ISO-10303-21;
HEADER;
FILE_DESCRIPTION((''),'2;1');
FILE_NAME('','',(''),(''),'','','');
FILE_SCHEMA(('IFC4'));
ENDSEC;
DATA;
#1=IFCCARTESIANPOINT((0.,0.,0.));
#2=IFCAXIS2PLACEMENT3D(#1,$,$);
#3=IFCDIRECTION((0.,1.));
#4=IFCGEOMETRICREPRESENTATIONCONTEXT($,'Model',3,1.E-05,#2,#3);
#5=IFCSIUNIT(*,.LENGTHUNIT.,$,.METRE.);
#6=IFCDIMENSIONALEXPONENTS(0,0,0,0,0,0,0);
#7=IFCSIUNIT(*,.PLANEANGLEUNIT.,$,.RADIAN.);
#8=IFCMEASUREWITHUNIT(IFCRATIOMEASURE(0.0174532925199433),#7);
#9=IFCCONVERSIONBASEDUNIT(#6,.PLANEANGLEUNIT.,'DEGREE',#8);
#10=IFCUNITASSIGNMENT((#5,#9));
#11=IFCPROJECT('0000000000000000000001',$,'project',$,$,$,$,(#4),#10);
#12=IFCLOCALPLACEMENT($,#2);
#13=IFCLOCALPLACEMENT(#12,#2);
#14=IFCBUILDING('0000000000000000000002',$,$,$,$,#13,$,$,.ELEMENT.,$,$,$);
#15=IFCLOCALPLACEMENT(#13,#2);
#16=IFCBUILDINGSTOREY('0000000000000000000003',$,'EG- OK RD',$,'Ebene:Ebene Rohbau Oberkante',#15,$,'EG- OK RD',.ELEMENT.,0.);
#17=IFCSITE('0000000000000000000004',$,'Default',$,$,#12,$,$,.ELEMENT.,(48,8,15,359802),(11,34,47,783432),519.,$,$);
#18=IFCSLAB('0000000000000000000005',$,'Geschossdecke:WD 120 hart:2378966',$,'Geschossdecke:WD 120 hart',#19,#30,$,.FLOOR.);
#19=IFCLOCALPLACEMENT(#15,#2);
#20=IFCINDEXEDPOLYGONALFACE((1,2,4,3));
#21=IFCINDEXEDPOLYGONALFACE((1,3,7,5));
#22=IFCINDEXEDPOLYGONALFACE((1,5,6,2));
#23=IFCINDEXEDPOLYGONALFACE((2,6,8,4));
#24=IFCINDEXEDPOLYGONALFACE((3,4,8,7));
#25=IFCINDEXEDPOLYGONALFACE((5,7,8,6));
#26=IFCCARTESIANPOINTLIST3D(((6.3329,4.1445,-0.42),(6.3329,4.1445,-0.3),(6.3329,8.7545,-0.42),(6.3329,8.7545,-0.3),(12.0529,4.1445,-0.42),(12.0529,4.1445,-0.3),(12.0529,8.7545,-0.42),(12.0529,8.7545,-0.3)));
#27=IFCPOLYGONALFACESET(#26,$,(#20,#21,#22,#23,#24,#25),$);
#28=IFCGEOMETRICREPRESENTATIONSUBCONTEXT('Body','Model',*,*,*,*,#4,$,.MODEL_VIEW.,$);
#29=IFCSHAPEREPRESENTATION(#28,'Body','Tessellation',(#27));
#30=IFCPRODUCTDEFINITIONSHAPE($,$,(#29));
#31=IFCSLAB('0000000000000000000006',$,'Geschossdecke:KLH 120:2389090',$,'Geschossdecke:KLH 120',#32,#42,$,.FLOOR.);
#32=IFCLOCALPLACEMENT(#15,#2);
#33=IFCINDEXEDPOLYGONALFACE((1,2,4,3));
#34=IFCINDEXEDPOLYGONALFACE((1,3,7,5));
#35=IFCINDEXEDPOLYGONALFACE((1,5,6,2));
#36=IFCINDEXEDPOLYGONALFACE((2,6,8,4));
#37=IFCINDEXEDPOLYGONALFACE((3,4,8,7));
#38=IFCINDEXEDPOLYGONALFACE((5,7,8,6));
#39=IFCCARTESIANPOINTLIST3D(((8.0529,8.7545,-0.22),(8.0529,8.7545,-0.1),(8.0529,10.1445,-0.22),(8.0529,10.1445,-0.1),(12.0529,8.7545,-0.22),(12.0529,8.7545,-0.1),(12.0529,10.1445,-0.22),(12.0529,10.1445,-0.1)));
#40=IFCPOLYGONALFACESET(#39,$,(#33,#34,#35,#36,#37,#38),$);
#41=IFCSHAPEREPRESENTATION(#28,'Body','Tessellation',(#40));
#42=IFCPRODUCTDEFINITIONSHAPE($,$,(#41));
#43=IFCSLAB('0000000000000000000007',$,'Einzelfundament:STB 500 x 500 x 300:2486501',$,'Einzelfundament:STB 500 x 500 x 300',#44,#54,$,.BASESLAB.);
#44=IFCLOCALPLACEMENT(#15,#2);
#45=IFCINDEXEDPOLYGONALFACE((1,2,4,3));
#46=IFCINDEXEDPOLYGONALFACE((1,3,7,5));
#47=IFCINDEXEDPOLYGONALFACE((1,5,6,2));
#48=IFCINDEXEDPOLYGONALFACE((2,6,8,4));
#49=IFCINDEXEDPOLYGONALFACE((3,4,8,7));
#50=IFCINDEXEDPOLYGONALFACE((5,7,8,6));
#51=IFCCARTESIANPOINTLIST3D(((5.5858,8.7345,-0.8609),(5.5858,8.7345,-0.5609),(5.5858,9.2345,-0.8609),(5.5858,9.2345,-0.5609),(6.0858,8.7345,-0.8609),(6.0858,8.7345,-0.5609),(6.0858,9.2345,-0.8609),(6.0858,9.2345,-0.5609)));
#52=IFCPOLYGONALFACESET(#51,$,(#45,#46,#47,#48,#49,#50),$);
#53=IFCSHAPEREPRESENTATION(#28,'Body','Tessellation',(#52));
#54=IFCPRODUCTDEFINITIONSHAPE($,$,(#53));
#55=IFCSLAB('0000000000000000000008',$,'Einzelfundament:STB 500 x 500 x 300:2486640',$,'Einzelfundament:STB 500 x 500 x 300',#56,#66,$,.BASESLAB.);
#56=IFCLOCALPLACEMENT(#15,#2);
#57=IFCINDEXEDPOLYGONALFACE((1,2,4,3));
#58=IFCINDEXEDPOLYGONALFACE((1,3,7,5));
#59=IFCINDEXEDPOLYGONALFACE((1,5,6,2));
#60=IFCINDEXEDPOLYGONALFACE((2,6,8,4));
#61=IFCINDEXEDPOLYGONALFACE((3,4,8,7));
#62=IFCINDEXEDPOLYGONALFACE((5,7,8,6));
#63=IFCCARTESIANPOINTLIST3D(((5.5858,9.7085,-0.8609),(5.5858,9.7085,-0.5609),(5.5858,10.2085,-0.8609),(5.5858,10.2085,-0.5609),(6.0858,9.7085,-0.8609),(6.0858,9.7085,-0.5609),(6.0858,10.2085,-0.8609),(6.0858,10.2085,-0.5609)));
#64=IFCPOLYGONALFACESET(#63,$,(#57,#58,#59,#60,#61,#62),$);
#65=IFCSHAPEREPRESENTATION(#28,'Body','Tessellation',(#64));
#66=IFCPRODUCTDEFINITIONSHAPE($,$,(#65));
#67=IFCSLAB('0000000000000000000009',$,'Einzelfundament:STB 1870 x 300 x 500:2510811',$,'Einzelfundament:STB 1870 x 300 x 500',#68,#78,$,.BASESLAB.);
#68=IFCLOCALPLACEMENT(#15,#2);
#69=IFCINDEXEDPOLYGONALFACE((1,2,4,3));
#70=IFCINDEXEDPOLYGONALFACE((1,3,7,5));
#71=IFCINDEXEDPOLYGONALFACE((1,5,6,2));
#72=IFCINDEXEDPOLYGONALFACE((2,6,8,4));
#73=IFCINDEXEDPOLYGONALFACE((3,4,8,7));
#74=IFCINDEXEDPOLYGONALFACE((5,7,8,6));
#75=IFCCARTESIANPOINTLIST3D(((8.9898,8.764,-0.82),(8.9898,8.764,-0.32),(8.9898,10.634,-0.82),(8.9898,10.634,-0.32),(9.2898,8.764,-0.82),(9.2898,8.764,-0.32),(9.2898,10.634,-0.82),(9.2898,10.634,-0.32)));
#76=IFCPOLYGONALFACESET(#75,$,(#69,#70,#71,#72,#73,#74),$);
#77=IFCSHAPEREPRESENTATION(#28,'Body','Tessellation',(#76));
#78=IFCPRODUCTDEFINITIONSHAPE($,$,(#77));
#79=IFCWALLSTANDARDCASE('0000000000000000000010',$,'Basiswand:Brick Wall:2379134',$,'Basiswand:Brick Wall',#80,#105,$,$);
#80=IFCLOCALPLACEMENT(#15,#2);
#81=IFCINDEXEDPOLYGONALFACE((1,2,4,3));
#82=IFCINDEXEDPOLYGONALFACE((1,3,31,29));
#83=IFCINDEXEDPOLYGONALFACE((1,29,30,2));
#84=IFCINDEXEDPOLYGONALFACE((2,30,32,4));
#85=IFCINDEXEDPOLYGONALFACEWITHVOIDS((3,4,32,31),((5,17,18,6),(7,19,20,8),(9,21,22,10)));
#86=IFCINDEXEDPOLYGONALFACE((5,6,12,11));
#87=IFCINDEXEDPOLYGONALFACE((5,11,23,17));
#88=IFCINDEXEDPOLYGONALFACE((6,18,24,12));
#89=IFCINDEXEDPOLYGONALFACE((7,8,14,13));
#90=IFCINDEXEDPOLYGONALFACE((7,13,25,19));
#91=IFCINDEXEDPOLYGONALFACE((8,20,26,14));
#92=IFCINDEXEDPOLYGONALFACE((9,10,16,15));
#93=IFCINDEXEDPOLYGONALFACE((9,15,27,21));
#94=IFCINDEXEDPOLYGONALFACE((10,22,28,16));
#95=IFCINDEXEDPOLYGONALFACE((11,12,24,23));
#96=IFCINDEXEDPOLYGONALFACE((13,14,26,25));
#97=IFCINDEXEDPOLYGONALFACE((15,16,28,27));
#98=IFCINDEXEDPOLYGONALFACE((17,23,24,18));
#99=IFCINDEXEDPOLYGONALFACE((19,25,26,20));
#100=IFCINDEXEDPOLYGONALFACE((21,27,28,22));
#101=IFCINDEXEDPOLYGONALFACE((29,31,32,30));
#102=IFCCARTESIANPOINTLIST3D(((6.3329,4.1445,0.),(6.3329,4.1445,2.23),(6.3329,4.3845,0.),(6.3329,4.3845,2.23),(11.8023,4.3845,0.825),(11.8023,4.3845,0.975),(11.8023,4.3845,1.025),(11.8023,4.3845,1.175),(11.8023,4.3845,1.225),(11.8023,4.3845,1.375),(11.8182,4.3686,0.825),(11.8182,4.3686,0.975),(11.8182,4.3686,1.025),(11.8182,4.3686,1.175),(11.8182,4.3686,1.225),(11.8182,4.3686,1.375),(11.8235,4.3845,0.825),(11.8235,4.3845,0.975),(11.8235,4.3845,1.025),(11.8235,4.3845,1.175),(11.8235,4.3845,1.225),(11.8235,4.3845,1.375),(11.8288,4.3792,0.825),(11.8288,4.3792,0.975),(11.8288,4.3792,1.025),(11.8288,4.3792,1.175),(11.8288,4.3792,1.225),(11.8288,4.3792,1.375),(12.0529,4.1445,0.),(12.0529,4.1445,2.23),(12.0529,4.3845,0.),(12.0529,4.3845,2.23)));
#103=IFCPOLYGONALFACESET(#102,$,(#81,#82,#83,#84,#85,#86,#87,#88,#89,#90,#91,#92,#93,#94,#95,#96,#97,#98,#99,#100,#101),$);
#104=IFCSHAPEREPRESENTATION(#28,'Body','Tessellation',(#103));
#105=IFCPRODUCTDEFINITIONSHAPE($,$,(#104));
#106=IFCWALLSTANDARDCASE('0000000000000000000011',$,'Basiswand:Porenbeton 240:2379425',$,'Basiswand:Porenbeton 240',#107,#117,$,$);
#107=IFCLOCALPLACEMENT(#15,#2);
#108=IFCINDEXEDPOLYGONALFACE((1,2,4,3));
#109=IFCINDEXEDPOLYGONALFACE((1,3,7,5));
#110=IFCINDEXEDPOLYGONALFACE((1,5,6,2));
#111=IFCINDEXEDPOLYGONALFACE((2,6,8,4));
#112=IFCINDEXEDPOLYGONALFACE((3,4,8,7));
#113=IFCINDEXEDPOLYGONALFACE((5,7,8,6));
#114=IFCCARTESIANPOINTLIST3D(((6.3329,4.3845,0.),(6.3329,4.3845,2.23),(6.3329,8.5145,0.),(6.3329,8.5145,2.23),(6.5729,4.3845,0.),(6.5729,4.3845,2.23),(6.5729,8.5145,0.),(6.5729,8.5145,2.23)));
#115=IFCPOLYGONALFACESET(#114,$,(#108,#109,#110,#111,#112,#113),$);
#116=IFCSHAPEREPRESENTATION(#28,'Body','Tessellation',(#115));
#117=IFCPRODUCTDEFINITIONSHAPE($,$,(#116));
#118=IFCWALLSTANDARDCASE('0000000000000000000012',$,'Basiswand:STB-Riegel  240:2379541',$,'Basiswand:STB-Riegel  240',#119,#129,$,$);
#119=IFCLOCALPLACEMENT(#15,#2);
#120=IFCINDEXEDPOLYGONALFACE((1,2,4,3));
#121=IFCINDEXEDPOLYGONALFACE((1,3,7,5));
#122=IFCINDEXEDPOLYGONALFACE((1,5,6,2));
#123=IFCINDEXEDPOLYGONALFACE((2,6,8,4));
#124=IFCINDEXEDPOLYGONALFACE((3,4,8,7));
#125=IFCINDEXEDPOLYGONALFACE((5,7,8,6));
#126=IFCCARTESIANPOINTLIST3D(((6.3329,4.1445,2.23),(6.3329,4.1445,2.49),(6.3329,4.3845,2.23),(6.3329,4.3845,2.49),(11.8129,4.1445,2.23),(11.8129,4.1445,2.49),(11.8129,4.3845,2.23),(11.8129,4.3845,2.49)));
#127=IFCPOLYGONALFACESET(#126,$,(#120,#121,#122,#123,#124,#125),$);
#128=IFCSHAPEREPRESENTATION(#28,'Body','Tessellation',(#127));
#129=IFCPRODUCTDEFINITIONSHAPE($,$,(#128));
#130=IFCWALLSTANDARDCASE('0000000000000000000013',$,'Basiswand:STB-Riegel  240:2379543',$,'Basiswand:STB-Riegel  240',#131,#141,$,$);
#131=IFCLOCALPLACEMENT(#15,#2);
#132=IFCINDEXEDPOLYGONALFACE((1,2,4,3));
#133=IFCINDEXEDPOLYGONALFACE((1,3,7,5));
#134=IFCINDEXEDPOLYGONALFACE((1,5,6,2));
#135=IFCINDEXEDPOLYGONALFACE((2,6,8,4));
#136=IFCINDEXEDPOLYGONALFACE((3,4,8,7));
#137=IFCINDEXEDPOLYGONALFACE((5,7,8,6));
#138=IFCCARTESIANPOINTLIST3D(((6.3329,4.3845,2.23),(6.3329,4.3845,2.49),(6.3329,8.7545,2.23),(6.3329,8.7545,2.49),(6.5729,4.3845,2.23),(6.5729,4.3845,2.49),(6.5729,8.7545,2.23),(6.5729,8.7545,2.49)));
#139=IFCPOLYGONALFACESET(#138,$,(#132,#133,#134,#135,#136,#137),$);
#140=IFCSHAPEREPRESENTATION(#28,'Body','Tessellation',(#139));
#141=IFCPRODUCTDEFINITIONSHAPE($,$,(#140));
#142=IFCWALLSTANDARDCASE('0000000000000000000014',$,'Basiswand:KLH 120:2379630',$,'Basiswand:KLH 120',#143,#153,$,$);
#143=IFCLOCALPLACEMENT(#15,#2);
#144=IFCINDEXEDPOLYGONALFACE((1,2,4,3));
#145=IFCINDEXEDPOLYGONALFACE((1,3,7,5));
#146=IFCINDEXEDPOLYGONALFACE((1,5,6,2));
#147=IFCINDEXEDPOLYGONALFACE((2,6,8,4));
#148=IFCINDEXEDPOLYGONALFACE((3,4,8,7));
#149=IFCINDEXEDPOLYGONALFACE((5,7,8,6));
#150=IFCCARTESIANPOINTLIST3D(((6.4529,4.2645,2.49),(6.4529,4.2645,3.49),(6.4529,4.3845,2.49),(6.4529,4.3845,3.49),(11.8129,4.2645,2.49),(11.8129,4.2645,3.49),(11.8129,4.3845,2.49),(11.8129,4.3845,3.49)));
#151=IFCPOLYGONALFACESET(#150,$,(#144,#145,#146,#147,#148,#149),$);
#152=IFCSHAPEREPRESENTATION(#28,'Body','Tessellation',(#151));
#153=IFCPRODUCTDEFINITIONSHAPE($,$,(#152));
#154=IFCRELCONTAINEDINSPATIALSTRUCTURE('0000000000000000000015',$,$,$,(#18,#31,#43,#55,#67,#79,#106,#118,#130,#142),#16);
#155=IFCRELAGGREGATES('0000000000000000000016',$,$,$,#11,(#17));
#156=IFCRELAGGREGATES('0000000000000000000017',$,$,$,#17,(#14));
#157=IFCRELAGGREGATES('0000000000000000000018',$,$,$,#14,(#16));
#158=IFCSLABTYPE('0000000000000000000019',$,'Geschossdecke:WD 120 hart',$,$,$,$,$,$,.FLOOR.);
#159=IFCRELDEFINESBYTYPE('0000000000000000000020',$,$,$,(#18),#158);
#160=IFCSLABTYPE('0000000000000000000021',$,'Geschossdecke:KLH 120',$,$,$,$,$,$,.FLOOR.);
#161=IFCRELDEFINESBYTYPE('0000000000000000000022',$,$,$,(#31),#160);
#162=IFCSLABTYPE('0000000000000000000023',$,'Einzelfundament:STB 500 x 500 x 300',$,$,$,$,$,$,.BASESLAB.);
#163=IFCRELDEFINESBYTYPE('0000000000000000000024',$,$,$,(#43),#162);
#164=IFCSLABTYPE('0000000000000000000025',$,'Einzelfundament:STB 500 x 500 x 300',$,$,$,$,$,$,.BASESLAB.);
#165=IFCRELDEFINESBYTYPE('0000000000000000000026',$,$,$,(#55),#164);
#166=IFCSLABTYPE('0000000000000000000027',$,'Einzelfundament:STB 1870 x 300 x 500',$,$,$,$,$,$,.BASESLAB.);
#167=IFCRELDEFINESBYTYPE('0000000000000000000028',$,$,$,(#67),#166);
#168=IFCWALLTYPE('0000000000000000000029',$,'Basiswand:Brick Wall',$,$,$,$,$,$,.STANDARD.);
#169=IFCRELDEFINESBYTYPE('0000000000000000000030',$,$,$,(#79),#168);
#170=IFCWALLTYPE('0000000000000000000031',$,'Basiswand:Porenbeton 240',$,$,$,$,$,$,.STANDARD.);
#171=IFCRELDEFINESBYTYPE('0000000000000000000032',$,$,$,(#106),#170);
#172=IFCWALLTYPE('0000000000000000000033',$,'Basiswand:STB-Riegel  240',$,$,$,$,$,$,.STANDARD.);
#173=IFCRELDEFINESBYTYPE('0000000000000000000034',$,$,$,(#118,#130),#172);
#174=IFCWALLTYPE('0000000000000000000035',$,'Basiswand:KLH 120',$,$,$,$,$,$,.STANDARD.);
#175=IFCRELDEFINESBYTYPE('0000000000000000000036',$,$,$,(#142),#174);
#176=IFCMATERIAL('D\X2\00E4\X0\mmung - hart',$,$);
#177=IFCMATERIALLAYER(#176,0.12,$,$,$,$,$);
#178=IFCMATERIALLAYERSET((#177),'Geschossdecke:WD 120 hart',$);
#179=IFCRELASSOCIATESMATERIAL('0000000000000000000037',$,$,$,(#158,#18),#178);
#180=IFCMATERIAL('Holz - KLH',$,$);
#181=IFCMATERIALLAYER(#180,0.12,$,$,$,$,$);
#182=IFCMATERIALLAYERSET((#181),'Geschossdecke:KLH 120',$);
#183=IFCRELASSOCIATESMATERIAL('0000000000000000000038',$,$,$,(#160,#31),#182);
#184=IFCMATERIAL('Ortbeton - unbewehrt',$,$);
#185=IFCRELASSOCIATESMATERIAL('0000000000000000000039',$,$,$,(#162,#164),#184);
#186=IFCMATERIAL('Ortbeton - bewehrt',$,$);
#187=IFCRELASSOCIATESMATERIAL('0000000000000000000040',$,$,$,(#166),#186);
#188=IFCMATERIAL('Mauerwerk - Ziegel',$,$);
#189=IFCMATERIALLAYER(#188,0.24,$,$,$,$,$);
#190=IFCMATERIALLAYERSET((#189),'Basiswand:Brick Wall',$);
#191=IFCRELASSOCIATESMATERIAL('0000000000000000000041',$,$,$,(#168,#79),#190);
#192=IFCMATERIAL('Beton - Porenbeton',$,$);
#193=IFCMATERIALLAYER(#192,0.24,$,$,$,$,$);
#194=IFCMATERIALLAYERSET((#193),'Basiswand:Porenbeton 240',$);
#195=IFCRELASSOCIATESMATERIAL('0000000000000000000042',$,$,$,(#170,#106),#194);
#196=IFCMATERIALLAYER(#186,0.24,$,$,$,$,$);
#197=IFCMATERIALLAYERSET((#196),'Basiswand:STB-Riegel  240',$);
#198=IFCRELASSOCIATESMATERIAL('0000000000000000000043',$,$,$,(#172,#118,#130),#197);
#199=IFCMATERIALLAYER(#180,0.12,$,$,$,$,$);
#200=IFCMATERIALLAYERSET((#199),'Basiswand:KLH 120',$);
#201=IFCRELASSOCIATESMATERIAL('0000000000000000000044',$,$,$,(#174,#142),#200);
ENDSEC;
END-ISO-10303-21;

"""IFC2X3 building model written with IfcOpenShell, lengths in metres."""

from ifc_helpers import new_model, entity, si_unit, converted_unit, direction, frame, frame_2d, origin, place, context, subcontext, project, spatial, rectangle, extrude, material, layer, layer_set, layer_usage, type_object, element, save


model = new_model("IFC2X3")

# Units and contexts
model_context = context("Model", 3, precision=1e-05, world=origin(), true_north=direction((0.0, 1.0)))
body_context = subcontext(model_context, "Body", "Model", "MODEL_VIEW")
ifc_project = project(units=[si_unit("LENGTHUNIT", "METRE"), converted_unit("PLANEANGLEUNIT", "DEGREE", entity("IfcRatioMeasure", 0.0174532925199433), si_unit("PLANEANGLEUNIT", "RADIAN"), dimensions=[0, 0, 0, 0, 0, 0, 0])], contexts=[model_context])

# Site, building, storey
site_placement = place(None, origin())
site = spatial("IfcSite", under=ifc_project, at=site_placement, Name="Default", CompositionType="ELEMENT", RefLatitude=(48, 8, 15, 359802), RefLongitude=(11, 34, 47, 783432), RefElevation=519.0)
building_placement = place(site_placement, origin())
building = spatial("IfcBuilding", under=site, at=building_placement, CompositionType="ELEMENT")
storey_placement = place(building_placement, origin())
storey = spatial("IfcBuildingStorey", under=building, at=storey_placement, Name="EG- OK RD", ObjectType="Ebene:Ebene Rohbau Oberkante", LongName="EG- OK RD", CompositionType="ELEMENT", Elevation=0.0)

# Slabs
ifc_material_1 = material(Name="Ortbeton - bewehrt")
ifc_material_2 = material(Name="Dämmung - hart")
ifc_layer_1 = layer(ifc_material_2, 0.12)
ifc_layer_set_1 = layer_set([ifc_layer_1], Name="Geschossdecke:WD 120 hart")
ifc_layer_usage_1 = layer_usage(ifc_layer_set_1, "AXIS3", "POSITIVE", 0.0)
slab_type_1 = type_object("IfcSlabType", Name="Geschossdecke:WD 120 hart", PredefinedType="FLOOR", material=ifc_layer_set_1)
slab_1_placement = place(storey_placement, origin())
element("IfcSlab", 1, at=slab_1_placement, inside=storey, type_object=slab_type_1, material=ifc_layer_usage_1, Name="Geschossdecke:WD 120 hart:2378966", ObjectType="Geschossdecke:WD 120 hart", PredefinedType="FLOOR", context=body_context, shape_type="SweptSolid", body=[
    extrude(rectangle(XDim=4.61, YDim=5.72, at=frame_2d((0.0, 0.0), x_axis=(1.0, 0.0))), frame((9.1929, 6.4495, -0.3), z_axis=(0.0, 0.0, -1.0), x_axis=(0.0, 1.0, 0.0)), (0.0, 0.0, 1.0), 0.12),
])
ifc_material_3 = material(Name="Holz - KLH")
ifc_layer_2 = layer(ifc_material_3, 0.12)
ifc_layer_set_2 = layer_set([ifc_layer_2], Name="Geschossdecke:KLH 120")
ifc_layer_usage_2 = layer_usage(ifc_layer_set_2, "AXIS3", "POSITIVE", 0.0)
slab_type_2 = type_object("IfcSlabType", Name="Geschossdecke:KLH 120", PredefinedType="FLOOR", material=ifc_layer_set_2)
slab_2_placement = place(storey_placement, origin())
element("IfcSlab", 2, at=slab_2_placement, inside=storey, type_object=slab_type_2, material=ifc_layer_usage_2, Name="Geschossdecke:KLH 120:2389090", ObjectType="Geschossdecke:KLH 120", PredefinedType="FLOOR", context=body_context, shape_type="SweptSolid", body=[
    extrude(rectangle(XDim=1.39, YDim=4.0, at=frame_2d((0.0, 0.0), x_axis=(1.0, 0.0))), frame((10.0529, 9.4495, -0.1), z_axis=(0.0, 0.0, -1.0), x_axis=(0.0, 1.0, 0.0)), (0.0, 0.0, 1.0), 0.12),
])
ifc_material_4 = material(Name="Ortbeton - unbewehrt")
slab_type_3 = type_object("IfcSlabType", Name="Einzelfundament:STB 500 x 500 x 300", PredefinedType="BASESLAB", material=ifc_material_4)
slab_3_placement = place(storey_placement, origin())
element("IfcSlab", 3, at=slab_3_placement, inside=storey, type_object=slab_type_3, Name="Einzelfundament:STB 500 x 500 x 300:2486501", ObjectType="Einzelfundament:STB 500 x 500 x 300", PredefinedType="BASESLAB", context=body_context, shape_type="SweptSolid", body=[
    extrude(rectangle(XDim=0.5, YDim=0.5, at=frame_2d((0.0, 0.0), x_axis=(1.0, 0.0))), frame((5.8358, 8.9845, -0.8609), z_axis=(0.0, 0.0, 1.0), x_axis=(-1.0, 0.0, 0.0)), (0.0, 0.0, 1.0), 0.3),
])
slab_type_4 = type_object("IfcSlabType", Name="Einzelfundament:STB 500 x 500 x 300", PredefinedType="BASESLAB", material=ifc_material_4)
slab_4_placement = place(storey_placement, origin())
element("IfcSlab", 4, at=slab_4_placement, inside=storey, type_object=slab_type_4, Name="Einzelfundament:STB 500 x 500 x 300:2486640", ObjectType="Einzelfundament:STB 500 x 500 x 300", PredefinedType="BASESLAB", context=body_context, shape_type="SweptSolid", body=[
    extrude(rectangle(XDim=0.5, YDim=0.5, at=frame_2d((0.0, 0.0), x_axis=(1.0, 0.0))), frame((5.8358, 9.9585, -0.8609), z_axis=(0.0, 0.0, 1.0), x_axis=(-1.0, 0.0, 0.0)), (0.0, 0.0, 1.0), 0.3),
])
slab_type_5 = type_object("IfcSlabType", Name="Einzelfundament:STB 1870 x 300 x 500", PredefinedType="BASESLAB", material=ifc_material_1)
slab_5_placement = place(storey_placement, origin())
element("IfcSlab", 5, at=slab_5_placement, inside=storey, type_object=slab_type_5, Name="Einzelfundament:STB 1870 x 300 x 500:2510811", ObjectType="Einzelfundament:STB 1870 x 300 x 500", PredefinedType="BASESLAB", context=body_context, shape_type="SweptSolid", body=[
    extrude(rectangle(XDim=1.87, YDim=0.3, at=frame_2d((0.0, 0.0), x_axis=(1.0, 0.0))), frame((9.1398, 9.699, -0.82), z_axis=(0.0, 0.0, 1.0), x_axis=(0.0, -1.0, 0.0)), (0.0, 0.0, 1.0), 0.5),
])

# Wall, openings
ifc_material_5 = material(Name="Mauerwerk - Ziegel")
ifc_layer_3 = layer(ifc_material_5, 0.24)
ifc_layer_set_3 = layer_set([ifc_layer_3], Name="Basiswand:Brick Wall")
ifc_layer_usage_3 = layer_usage(ifc_layer_set_3, "AXIS2", "POSITIVE", -0.12)
wall_type_1 = type_object("IfcWallType", Name="Basiswand:Brick Wall", PredefinedType="STANDARD", material=ifc_layer_set_3)
wall_1_placement = place(storey_placement, frame((6.3329, 4.2645, 0.0)))
wall_1 = element("IfcWallStandardCase", 6, at=wall_1_placement, inside=storey, type_object=wall_type_1, material=ifc_layer_usage_3, Name="Basiswand:Brick Wall:2379134", ObjectType="Basiswand:Brick Wall", context=body_context, shape_type="SweptSolid", body=[
    extrude(rectangle(XDim=5.72, YDim=0.24, at=frame_2d((2.86, 0.0), x_axis=(-1.0, 0.0))), origin(), (0.0, 0.0, 1.0), 2.23),
])
opening_1_placement = place(wall_1_placement, origin())
element("IfcOpeningElement", 7, at=opening_1_placement, cuts=wall_1, ObjectType="Recess", context=body_context, shape_type="SweptSolid", body=[
    extrude(rectangle(XDim=0.15, YDim=0.0285, at=frame_2d((0.0, 0.0), x_axis=(0.0, 1.0))), frame((5.4752, 0.1142, 1.1), z_axis=(0.707107, 0.707107, 0.0), x_axis=(0.707107, -0.707107, 0.0)), (0.0, 0.0, 1.0), 0.015),
])
opening_2_placement = place(wall_1_placement, origin())
element("IfcOpeningElement", 8, at=opening_2_placement, cuts=wall_1, ObjectType="Recess", context=body_context, shape_type="SweptSolid", body=[
    extrude(rectangle(XDim=0.15, YDim=0.0285, at=frame_2d((0.0, 0.0), x_axis=(0.0, 1.0))), frame((5.4752, 0.1142, 0.9), z_axis=(0.707107, 0.707107, 0.0), x_axis=(0.707107, -0.707107, 0.0)), (0.0, 0.0, 1.0), 0.015),
])
opening_3_placement = place(wall_1_placement, origin())
element("IfcOpeningElement", 9, at=opening_3_placement, cuts=wall_1, ObjectType="Recess", context=body_context, shape_type="SweptSolid", body=[
    extrude(rectangle(XDim=0.15, YDim=0.0285, at=frame_2d((0.0, 0.0), x_axis=(0.0, 1.0))), frame((5.4752, 0.1142, 1.3), z_axis=(0.707107, 0.707107, 0.0), x_axis=(0.707107, -0.707107, 0.0)), (0.0, 0.0, 1.0), 0.015),
])

# Walls
ifc_material_6 = material(Name="Beton - Porenbeton")
ifc_layer_4 = layer(ifc_material_6, 0.24)
ifc_layer_set_4 = layer_set([ifc_layer_4], Name="Basiswand:Porenbeton 240")
ifc_layer_usage_4 = layer_usage(ifc_layer_set_4, "AXIS2", "POSITIVE", -0.12)
wall_type_2 = type_object("IfcWallType", Name="Basiswand:Porenbeton 240", PredefinedType="STANDARD", material=ifc_layer_set_4)
wall_2_placement = place(storey_placement, frame((6.4529, 8.5145, 0.0), z_axis=(0.0, 0.0, 1.0), x_axis=(0.0, -1.0, 0.0)))
element("IfcWallStandardCase", 10, at=wall_2_placement, inside=storey, type_object=wall_type_2, material=ifc_layer_usage_4, Name="Basiswand:Porenbeton 240:2379425", ObjectType="Basiswand:Porenbeton 240", context=body_context, shape_type="SweptSolid", body=[
    extrude(rectangle(XDim=4.13, YDim=0.24, at=frame_2d((2.065, 0.0), x_axis=(-1.0, 0.0))), origin(), (0.0, 0.0, 1.0), 2.23),
])
ifc_layer_5 = layer(ifc_material_1, 0.24)
ifc_layer_set_5 = layer_set([ifc_layer_5], Name="Basiswand:STB-Riegel  240")
ifc_layer_usage_5 = layer_usage(ifc_layer_set_5, "AXIS2", "NEGATIVE", 0.12)
wall_type_3 = type_object("IfcWallType", Name="Basiswand:STB-Riegel  240", PredefinedType="STANDARD", material=ifc_layer_set_5)
wall_3_placement = place(storey_placement, frame((6.3329, 4.2645, 2.23)))
element("IfcWallStandardCase", 11, at=wall_3_placement, inside=storey, type_object=wall_type_3, material=ifc_layer_usage_5, Name="Basiswand:STB-Riegel  240:2379541", ObjectType="Basiswand:STB-Riegel  240", context=body_context, shape_type="SweptSolid", body=[
    extrude(rectangle(XDim=5.48, YDim=0.24, at=frame_2d((2.74, 0.0), x_axis=(-1.0, 0.0))), origin(), (0.0, 0.0, 1.0), 0.26),
])
ifc_layer_usage_6 = layer_usage(ifc_layer_set_5, "AXIS2", "NEGATIVE", 0.12)
wall_4_placement = place(storey_placement, frame((6.4529, 8.7545, 2.23), z_axis=(0.0, 0.0, 1.0), x_axis=(0.0, -1.0, 0.0)))
element("IfcWallStandardCase", 12, at=wall_4_placement, inside=storey, type_object=wall_type_3, material=ifc_layer_usage_6, Name="Basiswand:STB-Riegel  240:2379543", ObjectType="Basiswand:STB-Riegel  240", context=body_context, shape_type="SweptSolid", body=[
    extrude(rectangle(XDim=4.37, YDim=0.24, at=frame_2d((2.185, 0.0), x_axis=(-1.0, 0.0))), origin(), (0.0, 0.0, 1.0), 0.26),
])
ifc_layer_6 = layer(ifc_material_3, 0.12)
ifc_layer_set_6 = layer_set([ifc_layer_6], Name="Basiswand:KLH 120")
ifc_layer_usage_7 = layer_usage(ifc_layer_set_6, "AXIS2", "NEGATIVE", 0.06)
wall_type_4 = type_object("IfcWallType", Name="Basiswand:KLH 120", PredefinedType="STANDARD", material=ifc_layer_set_6)
wall_5_placement = place(storey_placement, frame((6.4529, 4.3245, 2.49)))
element("IfcWallStandardCase", 13, at=wall_5_placement, inside=storey, type_object=wall_type_4, material=ifc_layer_usage_7, Name="Basiswand:KLH 120:2379630", ObjectType="Basiswand:KLH 120", context=body_context, shape_type="SweptSolid", body=[
    extrude(rectangle(XDim=5.36, YDim=0.12, at=frame_2d((2.68, 0.0), x_axis=(-1.0, 0.0))), origin(), (0.0, 0.0, 1.0), 1.0),
])

save(model, "model.ifc")
